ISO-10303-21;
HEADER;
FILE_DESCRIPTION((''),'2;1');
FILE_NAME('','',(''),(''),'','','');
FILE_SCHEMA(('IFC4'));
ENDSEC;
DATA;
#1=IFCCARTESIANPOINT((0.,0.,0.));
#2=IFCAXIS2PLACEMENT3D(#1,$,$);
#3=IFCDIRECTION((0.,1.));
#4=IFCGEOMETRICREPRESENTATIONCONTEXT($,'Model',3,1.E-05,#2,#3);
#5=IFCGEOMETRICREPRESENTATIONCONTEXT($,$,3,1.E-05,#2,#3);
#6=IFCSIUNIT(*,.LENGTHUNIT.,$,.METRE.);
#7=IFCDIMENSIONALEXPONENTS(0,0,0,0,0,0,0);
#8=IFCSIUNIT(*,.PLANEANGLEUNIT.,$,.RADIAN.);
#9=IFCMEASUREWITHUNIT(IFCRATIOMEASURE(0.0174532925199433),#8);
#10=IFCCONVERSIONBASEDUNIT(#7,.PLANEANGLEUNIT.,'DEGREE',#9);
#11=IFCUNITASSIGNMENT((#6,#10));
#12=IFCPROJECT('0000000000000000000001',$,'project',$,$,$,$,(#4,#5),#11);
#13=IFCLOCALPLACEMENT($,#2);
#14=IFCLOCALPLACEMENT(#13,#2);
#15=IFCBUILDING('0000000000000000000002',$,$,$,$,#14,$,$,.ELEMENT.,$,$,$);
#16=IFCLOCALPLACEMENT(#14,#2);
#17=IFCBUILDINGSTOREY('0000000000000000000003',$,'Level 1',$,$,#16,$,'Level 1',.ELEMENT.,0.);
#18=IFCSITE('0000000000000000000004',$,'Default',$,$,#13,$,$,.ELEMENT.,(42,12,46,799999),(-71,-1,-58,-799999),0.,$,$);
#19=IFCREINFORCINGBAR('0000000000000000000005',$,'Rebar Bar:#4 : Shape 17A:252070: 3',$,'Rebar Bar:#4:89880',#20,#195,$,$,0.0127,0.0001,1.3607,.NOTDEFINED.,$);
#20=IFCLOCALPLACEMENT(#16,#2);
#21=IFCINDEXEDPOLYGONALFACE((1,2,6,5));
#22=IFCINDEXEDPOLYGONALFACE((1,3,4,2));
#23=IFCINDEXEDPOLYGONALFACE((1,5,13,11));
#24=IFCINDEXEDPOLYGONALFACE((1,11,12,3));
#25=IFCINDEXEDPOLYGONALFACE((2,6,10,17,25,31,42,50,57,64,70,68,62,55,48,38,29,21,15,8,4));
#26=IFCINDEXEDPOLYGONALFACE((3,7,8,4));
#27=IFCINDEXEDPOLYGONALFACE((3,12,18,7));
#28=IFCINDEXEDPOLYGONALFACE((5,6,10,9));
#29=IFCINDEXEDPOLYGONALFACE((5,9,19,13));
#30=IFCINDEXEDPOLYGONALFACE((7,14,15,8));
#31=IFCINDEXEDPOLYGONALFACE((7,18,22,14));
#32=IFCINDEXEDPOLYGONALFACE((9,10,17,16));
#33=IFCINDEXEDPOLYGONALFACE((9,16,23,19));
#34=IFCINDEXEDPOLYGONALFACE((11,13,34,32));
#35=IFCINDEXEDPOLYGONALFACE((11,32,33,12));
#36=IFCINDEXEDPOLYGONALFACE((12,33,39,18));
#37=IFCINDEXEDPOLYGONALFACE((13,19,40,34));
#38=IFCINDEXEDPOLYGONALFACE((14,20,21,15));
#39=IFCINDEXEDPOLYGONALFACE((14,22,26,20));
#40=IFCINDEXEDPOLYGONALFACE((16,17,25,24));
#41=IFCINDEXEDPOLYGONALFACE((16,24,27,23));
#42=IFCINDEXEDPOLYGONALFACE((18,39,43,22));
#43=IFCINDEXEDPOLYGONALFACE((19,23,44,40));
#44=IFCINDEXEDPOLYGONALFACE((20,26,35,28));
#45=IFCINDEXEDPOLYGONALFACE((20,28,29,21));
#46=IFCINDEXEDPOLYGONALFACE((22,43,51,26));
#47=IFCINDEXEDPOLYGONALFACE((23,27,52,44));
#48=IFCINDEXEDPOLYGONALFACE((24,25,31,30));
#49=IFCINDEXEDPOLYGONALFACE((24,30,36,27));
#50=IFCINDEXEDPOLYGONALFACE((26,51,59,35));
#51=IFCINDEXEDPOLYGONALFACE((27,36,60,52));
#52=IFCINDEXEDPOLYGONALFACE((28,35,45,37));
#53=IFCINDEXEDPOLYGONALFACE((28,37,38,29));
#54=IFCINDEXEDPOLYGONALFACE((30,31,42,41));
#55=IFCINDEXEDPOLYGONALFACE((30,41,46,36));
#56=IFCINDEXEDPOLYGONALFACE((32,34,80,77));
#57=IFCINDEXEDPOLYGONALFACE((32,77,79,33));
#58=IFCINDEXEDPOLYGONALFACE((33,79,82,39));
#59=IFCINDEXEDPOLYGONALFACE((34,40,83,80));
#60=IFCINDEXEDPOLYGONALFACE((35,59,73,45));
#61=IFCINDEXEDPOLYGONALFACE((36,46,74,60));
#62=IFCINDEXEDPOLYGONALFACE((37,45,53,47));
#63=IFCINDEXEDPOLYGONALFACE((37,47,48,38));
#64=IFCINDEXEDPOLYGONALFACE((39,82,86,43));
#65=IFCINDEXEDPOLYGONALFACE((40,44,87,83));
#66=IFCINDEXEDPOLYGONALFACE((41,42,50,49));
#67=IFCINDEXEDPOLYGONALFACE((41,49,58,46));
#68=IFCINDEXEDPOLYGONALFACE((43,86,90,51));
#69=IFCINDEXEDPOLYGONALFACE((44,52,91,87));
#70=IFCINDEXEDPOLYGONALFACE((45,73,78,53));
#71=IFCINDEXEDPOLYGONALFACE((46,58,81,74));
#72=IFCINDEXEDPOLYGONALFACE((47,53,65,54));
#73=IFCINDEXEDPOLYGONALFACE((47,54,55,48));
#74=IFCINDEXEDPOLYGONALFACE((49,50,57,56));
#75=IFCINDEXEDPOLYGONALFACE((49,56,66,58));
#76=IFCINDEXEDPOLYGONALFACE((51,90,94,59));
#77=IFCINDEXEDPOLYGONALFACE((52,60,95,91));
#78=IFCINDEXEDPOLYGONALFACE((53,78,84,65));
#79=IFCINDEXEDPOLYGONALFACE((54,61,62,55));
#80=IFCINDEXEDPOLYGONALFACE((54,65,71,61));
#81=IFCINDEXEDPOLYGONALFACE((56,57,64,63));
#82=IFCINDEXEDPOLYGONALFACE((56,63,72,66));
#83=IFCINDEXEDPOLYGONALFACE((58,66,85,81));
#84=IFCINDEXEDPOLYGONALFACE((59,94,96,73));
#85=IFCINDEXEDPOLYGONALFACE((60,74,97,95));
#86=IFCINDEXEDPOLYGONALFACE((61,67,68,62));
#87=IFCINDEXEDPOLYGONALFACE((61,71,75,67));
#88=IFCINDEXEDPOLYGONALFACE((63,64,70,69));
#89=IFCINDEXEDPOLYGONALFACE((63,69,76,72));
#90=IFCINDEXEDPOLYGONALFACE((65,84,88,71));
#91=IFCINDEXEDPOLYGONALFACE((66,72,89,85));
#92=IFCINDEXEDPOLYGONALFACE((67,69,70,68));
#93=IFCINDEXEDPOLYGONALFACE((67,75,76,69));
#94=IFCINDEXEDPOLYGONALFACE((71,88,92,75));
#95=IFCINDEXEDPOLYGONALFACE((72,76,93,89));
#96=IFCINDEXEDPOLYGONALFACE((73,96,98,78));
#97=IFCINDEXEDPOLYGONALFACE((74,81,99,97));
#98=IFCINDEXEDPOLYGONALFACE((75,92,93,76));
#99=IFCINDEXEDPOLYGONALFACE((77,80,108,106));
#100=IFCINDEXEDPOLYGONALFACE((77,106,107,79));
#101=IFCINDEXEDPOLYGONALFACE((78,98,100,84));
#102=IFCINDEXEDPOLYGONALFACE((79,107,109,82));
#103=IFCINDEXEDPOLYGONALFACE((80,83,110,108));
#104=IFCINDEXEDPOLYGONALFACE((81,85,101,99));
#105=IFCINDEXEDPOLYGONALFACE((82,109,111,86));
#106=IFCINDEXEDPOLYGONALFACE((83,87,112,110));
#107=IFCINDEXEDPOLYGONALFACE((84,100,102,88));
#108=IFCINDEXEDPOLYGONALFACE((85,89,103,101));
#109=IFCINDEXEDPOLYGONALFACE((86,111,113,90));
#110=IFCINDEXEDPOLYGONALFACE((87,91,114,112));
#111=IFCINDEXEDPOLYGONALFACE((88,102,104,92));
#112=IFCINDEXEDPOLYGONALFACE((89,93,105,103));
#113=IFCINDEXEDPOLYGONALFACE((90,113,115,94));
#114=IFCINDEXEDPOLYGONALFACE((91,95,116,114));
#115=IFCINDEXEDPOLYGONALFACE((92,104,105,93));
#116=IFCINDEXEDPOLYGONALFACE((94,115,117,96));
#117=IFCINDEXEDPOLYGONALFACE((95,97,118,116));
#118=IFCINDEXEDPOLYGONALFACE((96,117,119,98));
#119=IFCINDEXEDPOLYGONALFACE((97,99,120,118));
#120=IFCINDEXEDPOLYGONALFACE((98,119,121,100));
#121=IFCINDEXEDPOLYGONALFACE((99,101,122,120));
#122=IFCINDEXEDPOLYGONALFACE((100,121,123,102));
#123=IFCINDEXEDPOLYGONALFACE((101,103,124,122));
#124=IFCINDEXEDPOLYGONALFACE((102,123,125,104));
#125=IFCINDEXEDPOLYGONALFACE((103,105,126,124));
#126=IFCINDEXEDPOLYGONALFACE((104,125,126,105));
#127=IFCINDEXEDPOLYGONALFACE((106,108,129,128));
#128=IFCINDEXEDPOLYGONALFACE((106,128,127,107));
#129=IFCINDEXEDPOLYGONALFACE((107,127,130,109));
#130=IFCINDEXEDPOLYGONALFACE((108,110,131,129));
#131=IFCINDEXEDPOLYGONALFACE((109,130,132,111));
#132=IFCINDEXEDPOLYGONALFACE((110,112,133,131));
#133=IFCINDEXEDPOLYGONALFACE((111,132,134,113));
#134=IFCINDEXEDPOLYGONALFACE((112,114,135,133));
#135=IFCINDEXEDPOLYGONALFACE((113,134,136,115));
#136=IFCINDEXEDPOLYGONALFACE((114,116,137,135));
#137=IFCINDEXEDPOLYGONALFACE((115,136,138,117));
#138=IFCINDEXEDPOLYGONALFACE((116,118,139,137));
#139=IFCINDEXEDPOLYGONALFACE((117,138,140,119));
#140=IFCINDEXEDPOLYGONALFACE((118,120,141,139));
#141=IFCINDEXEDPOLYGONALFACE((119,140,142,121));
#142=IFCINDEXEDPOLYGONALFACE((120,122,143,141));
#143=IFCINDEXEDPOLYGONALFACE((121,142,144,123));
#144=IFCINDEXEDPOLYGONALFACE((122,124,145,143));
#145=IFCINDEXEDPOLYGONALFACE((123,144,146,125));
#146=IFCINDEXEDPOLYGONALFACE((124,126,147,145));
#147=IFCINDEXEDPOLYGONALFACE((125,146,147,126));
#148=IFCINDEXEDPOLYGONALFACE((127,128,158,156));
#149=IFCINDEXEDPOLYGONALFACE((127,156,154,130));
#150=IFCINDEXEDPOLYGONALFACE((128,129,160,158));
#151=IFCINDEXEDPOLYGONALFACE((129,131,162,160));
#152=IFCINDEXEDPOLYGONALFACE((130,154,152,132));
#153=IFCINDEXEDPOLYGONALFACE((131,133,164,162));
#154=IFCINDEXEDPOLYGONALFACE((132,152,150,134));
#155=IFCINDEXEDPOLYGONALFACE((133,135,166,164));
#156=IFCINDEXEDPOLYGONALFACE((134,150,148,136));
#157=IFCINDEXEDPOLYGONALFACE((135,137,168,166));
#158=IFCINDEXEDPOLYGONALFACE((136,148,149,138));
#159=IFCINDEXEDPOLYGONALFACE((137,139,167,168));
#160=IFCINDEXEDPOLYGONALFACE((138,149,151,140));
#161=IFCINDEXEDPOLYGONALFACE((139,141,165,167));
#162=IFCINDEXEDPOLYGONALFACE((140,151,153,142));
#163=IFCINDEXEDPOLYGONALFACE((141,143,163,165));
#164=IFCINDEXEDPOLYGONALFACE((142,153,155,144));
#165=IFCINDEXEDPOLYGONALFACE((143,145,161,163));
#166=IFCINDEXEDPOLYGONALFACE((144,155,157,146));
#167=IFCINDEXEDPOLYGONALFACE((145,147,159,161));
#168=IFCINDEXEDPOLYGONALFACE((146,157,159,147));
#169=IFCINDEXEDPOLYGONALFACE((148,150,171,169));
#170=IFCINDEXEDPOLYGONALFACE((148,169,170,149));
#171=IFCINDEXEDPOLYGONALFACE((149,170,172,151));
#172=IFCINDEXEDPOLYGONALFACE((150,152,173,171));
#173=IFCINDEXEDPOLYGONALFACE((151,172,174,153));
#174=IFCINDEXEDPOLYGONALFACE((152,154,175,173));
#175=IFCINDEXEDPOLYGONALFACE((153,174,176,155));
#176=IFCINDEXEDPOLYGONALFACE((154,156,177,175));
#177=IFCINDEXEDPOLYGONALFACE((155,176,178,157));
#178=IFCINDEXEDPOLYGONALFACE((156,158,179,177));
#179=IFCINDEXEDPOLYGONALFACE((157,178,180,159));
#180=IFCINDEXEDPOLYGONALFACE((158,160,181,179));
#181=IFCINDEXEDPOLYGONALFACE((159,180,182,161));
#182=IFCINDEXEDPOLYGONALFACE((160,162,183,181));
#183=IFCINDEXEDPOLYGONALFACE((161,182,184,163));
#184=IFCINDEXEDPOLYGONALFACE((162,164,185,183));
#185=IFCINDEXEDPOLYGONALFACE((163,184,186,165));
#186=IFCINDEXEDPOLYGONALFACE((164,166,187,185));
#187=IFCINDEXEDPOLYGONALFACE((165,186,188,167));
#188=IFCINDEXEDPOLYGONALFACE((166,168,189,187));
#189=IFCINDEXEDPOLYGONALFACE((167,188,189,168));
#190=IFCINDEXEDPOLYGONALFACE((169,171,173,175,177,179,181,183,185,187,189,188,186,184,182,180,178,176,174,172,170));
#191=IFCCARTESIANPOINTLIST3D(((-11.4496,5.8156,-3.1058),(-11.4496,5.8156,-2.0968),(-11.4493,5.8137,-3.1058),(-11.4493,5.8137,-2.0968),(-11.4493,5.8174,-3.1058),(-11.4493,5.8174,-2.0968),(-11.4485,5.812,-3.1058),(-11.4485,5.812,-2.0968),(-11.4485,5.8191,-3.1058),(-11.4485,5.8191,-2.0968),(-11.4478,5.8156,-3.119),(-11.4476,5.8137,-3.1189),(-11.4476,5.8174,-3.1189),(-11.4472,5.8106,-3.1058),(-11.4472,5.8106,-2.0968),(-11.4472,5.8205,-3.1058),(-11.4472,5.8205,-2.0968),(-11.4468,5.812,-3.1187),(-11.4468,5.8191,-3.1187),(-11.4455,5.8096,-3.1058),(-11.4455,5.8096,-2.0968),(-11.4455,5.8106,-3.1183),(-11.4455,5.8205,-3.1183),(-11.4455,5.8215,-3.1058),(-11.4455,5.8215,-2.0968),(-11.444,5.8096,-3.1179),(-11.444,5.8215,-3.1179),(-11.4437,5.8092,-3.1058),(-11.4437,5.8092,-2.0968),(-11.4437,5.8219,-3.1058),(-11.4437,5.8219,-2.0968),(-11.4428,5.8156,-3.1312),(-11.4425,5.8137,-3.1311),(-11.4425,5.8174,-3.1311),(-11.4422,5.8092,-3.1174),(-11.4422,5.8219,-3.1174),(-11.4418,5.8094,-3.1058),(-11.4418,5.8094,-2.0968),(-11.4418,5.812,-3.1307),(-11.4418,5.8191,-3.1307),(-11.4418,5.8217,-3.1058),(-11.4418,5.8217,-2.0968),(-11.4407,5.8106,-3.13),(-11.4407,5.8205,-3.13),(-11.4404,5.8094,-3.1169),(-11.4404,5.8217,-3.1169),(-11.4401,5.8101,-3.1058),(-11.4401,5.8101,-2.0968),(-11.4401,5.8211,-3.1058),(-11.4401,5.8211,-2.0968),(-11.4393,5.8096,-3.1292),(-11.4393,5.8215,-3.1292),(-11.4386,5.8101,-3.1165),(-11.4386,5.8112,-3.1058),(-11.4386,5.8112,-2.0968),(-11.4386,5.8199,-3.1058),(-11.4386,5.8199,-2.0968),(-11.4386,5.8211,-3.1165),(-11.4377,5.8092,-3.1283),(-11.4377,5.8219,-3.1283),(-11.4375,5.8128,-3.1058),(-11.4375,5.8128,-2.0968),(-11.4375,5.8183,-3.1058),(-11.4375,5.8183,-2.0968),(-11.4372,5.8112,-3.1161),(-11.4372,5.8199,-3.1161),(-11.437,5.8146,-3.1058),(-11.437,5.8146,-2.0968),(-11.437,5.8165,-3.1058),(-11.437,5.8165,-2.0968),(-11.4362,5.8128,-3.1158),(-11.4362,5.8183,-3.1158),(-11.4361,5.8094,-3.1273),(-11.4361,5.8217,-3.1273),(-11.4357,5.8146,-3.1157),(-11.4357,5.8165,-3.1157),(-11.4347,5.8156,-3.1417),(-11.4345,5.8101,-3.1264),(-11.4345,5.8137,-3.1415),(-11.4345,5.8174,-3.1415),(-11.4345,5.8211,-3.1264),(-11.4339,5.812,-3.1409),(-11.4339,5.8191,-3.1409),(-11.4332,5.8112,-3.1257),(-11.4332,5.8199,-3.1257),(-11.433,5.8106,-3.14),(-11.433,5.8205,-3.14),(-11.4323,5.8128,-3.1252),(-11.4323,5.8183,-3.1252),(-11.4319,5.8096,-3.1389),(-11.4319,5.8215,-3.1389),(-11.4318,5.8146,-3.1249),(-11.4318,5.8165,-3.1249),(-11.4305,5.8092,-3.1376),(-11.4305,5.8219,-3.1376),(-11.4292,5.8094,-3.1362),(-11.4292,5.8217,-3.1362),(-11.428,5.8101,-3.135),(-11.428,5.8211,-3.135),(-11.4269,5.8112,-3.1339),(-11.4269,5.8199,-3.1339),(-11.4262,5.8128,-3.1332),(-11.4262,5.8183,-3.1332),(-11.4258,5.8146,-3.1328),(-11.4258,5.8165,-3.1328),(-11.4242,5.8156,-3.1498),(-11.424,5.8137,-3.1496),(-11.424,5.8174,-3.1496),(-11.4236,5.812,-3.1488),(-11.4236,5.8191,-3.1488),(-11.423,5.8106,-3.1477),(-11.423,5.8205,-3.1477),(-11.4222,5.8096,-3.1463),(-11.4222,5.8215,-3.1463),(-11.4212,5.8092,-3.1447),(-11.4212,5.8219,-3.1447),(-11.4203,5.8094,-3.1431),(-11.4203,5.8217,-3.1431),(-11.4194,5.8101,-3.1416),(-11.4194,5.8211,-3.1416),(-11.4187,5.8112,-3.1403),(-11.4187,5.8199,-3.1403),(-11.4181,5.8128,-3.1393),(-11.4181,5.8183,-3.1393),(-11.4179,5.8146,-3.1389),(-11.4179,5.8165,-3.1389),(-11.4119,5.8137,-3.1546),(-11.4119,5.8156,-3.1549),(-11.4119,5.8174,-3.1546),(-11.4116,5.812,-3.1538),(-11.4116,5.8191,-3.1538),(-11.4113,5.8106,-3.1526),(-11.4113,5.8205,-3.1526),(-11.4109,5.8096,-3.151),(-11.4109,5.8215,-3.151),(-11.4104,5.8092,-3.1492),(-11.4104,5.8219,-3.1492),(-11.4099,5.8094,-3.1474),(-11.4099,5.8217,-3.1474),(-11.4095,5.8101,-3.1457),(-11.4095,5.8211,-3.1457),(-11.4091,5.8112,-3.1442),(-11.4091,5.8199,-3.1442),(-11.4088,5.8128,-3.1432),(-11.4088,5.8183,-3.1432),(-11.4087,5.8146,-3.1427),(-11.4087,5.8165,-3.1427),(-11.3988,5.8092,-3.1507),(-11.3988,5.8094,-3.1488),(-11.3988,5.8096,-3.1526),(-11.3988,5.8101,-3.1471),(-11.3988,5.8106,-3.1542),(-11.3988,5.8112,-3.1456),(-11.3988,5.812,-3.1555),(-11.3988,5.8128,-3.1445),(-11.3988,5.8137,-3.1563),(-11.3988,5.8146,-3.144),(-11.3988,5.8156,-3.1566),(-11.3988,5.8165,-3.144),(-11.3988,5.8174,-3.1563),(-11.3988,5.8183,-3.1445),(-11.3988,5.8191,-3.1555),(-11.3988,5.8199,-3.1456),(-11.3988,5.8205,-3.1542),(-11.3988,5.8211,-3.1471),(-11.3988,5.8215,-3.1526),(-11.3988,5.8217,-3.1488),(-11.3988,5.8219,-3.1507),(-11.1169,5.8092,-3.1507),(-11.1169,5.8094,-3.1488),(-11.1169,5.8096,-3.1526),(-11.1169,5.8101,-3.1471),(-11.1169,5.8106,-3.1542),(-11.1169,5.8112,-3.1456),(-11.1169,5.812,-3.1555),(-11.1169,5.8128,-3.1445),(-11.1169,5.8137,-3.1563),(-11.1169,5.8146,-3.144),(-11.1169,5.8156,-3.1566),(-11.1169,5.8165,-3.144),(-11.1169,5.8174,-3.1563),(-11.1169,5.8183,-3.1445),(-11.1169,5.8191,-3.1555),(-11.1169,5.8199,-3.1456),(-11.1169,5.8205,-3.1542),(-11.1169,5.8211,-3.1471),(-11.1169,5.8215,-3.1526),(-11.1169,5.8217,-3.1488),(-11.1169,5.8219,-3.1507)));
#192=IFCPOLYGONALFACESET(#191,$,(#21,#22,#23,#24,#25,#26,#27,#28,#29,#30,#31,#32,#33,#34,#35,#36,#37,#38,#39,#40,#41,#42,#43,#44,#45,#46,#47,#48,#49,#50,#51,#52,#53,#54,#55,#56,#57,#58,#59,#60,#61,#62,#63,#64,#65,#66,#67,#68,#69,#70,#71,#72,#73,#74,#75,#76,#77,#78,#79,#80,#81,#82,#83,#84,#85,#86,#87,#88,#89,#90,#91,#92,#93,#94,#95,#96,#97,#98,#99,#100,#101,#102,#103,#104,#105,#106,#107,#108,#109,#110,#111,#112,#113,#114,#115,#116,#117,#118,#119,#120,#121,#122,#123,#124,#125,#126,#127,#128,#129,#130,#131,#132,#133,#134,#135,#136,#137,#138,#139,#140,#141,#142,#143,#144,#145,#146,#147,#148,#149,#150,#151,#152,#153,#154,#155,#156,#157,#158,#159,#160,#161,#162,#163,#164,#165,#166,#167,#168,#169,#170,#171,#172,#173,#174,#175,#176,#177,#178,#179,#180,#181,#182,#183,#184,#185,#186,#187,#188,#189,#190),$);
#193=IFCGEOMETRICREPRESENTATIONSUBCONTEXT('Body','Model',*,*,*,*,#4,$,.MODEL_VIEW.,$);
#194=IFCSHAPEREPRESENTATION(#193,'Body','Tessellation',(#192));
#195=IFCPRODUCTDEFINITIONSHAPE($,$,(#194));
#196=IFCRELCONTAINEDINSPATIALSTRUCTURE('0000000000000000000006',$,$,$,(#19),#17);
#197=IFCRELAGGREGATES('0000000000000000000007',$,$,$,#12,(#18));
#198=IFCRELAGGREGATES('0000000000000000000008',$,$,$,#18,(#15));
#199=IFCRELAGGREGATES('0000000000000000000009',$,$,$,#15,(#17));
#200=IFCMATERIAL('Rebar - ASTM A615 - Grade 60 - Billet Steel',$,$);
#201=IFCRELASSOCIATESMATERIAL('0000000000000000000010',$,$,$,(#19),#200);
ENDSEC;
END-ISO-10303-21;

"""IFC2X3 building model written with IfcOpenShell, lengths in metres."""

from ifc_helpers import new_model, entity, si_unit, converted_unit, direction, origin, place, context, subcontext, project, spatial, material, element, save


model = new_model("IFC2X3")

# Units and contexts
model_context = context("Model", 3, precision=1e-05, world=origin(), true_north=direction((0.0, 1.0)))
context_of_model = context(None, 3, precision=1e-05, world=origin(), true_north=direction((0.0, 1.0)))
body_context = subcontext(model_context, "Body", "Model", "MODEL_VIEW")
ifc_project = project(units=[si_unit("LENGTHUNIT", "METRE"), converted_unit("PLANEANGLEUNIT", "DEGREE", entity("IfcRatioMeasure", 0.0174532925199433), si_unit("PLANEANGLEUNIT", "RADIAN"), dimensions=[0, 0, 0, 0, 0, 0, 0])], contexts=[model_context, context_of_model])

# Site, building, storey
site_placement = place(None, origin())
site = spatial("IfcSite", under=ifc_project, at=site_placement, Name="Default", CompositionType="ELEMENT", RefLatitude=(42, 12, 46, 799999), RefLongitude=(-71, -1, -58, -799999), RefElevation=0.0)
building_placement = place(site_placement, origin())
building = spatial("IfcBuilding", under=site, at=building_placement, CompositionType="ELEMENT")
storey_placement = place(building_placement, origin())
storey = spatial("IfcBuildingStorey", under=building, at=storey_placement, Name="Level 1", LongName="Level 1", CompositionType="ELEMENT", Elevation=0.0)

# Reinforcing bar
ifc_material_1 = material(Name="Rebar - ASTM A615 - Grade 60 - Billet Steel")
reinforcing_bar_1_placement = place(storey_placement, origin())
element("IfcReinforcingBar", 1, at=reinforcing_bar_1_placement, inside=storey, material=ifc_material_1, Name="Rebar Bar:#4 : Shape 17A:252070: 3", ObjectType="Rebar Bar:#4:89880", BarLength=1.3607, BarRole="NOTDEFINED", CrossSectionArea=0.0001, NominalDiameter=0.0127, context=body_context, shape_type="AdvancedSweptSolid", body=[
    entity("IfcSweptDiskSolid", entity("IfcCompositeCurve", [entity("IfcCompositeCurveSegment", "CONTINUOUS", True, entity("IfcPolyline", [entity("IfcCartesianPoint", [-11.4432, 5.8156, -2.0968]), entity("IfcCartesianPoint", [-11.4432, 5.8156, -3.1058])])), entity("IfcCompositeCurveSegment", "CONTINUOUS", True, entity("IfcTrimmedCurve", entity("IfcCircle", entity("IfcAxis2Placement3D", entity("IfcCartesianPoint", [-11.3988, 5.8156, -3.1058]), entity("IfcDirection", [0.0, -1.0, 0.0]), entity("IfcDirection", [0.0, 0.0, -1.0])), 0.0445), [entity("IfcParameterValue", 270.0)], [entity("IfcParameterValue", 360.0)], True, "PARAMETER")), entity("IfcCompositeCurveSegment", "CONTINUOUS", True, entity("IfcPolyline", [entity("IfcCartesianPoint", [-11.3988, 5.8156, -3.1503]), entity("IfcCartesianPoint", [-11.1169, 5.8156, -3.1503])]))], False), 0.0063, None, 0.0, 92.0),
])

save(model, "model.ifc")
